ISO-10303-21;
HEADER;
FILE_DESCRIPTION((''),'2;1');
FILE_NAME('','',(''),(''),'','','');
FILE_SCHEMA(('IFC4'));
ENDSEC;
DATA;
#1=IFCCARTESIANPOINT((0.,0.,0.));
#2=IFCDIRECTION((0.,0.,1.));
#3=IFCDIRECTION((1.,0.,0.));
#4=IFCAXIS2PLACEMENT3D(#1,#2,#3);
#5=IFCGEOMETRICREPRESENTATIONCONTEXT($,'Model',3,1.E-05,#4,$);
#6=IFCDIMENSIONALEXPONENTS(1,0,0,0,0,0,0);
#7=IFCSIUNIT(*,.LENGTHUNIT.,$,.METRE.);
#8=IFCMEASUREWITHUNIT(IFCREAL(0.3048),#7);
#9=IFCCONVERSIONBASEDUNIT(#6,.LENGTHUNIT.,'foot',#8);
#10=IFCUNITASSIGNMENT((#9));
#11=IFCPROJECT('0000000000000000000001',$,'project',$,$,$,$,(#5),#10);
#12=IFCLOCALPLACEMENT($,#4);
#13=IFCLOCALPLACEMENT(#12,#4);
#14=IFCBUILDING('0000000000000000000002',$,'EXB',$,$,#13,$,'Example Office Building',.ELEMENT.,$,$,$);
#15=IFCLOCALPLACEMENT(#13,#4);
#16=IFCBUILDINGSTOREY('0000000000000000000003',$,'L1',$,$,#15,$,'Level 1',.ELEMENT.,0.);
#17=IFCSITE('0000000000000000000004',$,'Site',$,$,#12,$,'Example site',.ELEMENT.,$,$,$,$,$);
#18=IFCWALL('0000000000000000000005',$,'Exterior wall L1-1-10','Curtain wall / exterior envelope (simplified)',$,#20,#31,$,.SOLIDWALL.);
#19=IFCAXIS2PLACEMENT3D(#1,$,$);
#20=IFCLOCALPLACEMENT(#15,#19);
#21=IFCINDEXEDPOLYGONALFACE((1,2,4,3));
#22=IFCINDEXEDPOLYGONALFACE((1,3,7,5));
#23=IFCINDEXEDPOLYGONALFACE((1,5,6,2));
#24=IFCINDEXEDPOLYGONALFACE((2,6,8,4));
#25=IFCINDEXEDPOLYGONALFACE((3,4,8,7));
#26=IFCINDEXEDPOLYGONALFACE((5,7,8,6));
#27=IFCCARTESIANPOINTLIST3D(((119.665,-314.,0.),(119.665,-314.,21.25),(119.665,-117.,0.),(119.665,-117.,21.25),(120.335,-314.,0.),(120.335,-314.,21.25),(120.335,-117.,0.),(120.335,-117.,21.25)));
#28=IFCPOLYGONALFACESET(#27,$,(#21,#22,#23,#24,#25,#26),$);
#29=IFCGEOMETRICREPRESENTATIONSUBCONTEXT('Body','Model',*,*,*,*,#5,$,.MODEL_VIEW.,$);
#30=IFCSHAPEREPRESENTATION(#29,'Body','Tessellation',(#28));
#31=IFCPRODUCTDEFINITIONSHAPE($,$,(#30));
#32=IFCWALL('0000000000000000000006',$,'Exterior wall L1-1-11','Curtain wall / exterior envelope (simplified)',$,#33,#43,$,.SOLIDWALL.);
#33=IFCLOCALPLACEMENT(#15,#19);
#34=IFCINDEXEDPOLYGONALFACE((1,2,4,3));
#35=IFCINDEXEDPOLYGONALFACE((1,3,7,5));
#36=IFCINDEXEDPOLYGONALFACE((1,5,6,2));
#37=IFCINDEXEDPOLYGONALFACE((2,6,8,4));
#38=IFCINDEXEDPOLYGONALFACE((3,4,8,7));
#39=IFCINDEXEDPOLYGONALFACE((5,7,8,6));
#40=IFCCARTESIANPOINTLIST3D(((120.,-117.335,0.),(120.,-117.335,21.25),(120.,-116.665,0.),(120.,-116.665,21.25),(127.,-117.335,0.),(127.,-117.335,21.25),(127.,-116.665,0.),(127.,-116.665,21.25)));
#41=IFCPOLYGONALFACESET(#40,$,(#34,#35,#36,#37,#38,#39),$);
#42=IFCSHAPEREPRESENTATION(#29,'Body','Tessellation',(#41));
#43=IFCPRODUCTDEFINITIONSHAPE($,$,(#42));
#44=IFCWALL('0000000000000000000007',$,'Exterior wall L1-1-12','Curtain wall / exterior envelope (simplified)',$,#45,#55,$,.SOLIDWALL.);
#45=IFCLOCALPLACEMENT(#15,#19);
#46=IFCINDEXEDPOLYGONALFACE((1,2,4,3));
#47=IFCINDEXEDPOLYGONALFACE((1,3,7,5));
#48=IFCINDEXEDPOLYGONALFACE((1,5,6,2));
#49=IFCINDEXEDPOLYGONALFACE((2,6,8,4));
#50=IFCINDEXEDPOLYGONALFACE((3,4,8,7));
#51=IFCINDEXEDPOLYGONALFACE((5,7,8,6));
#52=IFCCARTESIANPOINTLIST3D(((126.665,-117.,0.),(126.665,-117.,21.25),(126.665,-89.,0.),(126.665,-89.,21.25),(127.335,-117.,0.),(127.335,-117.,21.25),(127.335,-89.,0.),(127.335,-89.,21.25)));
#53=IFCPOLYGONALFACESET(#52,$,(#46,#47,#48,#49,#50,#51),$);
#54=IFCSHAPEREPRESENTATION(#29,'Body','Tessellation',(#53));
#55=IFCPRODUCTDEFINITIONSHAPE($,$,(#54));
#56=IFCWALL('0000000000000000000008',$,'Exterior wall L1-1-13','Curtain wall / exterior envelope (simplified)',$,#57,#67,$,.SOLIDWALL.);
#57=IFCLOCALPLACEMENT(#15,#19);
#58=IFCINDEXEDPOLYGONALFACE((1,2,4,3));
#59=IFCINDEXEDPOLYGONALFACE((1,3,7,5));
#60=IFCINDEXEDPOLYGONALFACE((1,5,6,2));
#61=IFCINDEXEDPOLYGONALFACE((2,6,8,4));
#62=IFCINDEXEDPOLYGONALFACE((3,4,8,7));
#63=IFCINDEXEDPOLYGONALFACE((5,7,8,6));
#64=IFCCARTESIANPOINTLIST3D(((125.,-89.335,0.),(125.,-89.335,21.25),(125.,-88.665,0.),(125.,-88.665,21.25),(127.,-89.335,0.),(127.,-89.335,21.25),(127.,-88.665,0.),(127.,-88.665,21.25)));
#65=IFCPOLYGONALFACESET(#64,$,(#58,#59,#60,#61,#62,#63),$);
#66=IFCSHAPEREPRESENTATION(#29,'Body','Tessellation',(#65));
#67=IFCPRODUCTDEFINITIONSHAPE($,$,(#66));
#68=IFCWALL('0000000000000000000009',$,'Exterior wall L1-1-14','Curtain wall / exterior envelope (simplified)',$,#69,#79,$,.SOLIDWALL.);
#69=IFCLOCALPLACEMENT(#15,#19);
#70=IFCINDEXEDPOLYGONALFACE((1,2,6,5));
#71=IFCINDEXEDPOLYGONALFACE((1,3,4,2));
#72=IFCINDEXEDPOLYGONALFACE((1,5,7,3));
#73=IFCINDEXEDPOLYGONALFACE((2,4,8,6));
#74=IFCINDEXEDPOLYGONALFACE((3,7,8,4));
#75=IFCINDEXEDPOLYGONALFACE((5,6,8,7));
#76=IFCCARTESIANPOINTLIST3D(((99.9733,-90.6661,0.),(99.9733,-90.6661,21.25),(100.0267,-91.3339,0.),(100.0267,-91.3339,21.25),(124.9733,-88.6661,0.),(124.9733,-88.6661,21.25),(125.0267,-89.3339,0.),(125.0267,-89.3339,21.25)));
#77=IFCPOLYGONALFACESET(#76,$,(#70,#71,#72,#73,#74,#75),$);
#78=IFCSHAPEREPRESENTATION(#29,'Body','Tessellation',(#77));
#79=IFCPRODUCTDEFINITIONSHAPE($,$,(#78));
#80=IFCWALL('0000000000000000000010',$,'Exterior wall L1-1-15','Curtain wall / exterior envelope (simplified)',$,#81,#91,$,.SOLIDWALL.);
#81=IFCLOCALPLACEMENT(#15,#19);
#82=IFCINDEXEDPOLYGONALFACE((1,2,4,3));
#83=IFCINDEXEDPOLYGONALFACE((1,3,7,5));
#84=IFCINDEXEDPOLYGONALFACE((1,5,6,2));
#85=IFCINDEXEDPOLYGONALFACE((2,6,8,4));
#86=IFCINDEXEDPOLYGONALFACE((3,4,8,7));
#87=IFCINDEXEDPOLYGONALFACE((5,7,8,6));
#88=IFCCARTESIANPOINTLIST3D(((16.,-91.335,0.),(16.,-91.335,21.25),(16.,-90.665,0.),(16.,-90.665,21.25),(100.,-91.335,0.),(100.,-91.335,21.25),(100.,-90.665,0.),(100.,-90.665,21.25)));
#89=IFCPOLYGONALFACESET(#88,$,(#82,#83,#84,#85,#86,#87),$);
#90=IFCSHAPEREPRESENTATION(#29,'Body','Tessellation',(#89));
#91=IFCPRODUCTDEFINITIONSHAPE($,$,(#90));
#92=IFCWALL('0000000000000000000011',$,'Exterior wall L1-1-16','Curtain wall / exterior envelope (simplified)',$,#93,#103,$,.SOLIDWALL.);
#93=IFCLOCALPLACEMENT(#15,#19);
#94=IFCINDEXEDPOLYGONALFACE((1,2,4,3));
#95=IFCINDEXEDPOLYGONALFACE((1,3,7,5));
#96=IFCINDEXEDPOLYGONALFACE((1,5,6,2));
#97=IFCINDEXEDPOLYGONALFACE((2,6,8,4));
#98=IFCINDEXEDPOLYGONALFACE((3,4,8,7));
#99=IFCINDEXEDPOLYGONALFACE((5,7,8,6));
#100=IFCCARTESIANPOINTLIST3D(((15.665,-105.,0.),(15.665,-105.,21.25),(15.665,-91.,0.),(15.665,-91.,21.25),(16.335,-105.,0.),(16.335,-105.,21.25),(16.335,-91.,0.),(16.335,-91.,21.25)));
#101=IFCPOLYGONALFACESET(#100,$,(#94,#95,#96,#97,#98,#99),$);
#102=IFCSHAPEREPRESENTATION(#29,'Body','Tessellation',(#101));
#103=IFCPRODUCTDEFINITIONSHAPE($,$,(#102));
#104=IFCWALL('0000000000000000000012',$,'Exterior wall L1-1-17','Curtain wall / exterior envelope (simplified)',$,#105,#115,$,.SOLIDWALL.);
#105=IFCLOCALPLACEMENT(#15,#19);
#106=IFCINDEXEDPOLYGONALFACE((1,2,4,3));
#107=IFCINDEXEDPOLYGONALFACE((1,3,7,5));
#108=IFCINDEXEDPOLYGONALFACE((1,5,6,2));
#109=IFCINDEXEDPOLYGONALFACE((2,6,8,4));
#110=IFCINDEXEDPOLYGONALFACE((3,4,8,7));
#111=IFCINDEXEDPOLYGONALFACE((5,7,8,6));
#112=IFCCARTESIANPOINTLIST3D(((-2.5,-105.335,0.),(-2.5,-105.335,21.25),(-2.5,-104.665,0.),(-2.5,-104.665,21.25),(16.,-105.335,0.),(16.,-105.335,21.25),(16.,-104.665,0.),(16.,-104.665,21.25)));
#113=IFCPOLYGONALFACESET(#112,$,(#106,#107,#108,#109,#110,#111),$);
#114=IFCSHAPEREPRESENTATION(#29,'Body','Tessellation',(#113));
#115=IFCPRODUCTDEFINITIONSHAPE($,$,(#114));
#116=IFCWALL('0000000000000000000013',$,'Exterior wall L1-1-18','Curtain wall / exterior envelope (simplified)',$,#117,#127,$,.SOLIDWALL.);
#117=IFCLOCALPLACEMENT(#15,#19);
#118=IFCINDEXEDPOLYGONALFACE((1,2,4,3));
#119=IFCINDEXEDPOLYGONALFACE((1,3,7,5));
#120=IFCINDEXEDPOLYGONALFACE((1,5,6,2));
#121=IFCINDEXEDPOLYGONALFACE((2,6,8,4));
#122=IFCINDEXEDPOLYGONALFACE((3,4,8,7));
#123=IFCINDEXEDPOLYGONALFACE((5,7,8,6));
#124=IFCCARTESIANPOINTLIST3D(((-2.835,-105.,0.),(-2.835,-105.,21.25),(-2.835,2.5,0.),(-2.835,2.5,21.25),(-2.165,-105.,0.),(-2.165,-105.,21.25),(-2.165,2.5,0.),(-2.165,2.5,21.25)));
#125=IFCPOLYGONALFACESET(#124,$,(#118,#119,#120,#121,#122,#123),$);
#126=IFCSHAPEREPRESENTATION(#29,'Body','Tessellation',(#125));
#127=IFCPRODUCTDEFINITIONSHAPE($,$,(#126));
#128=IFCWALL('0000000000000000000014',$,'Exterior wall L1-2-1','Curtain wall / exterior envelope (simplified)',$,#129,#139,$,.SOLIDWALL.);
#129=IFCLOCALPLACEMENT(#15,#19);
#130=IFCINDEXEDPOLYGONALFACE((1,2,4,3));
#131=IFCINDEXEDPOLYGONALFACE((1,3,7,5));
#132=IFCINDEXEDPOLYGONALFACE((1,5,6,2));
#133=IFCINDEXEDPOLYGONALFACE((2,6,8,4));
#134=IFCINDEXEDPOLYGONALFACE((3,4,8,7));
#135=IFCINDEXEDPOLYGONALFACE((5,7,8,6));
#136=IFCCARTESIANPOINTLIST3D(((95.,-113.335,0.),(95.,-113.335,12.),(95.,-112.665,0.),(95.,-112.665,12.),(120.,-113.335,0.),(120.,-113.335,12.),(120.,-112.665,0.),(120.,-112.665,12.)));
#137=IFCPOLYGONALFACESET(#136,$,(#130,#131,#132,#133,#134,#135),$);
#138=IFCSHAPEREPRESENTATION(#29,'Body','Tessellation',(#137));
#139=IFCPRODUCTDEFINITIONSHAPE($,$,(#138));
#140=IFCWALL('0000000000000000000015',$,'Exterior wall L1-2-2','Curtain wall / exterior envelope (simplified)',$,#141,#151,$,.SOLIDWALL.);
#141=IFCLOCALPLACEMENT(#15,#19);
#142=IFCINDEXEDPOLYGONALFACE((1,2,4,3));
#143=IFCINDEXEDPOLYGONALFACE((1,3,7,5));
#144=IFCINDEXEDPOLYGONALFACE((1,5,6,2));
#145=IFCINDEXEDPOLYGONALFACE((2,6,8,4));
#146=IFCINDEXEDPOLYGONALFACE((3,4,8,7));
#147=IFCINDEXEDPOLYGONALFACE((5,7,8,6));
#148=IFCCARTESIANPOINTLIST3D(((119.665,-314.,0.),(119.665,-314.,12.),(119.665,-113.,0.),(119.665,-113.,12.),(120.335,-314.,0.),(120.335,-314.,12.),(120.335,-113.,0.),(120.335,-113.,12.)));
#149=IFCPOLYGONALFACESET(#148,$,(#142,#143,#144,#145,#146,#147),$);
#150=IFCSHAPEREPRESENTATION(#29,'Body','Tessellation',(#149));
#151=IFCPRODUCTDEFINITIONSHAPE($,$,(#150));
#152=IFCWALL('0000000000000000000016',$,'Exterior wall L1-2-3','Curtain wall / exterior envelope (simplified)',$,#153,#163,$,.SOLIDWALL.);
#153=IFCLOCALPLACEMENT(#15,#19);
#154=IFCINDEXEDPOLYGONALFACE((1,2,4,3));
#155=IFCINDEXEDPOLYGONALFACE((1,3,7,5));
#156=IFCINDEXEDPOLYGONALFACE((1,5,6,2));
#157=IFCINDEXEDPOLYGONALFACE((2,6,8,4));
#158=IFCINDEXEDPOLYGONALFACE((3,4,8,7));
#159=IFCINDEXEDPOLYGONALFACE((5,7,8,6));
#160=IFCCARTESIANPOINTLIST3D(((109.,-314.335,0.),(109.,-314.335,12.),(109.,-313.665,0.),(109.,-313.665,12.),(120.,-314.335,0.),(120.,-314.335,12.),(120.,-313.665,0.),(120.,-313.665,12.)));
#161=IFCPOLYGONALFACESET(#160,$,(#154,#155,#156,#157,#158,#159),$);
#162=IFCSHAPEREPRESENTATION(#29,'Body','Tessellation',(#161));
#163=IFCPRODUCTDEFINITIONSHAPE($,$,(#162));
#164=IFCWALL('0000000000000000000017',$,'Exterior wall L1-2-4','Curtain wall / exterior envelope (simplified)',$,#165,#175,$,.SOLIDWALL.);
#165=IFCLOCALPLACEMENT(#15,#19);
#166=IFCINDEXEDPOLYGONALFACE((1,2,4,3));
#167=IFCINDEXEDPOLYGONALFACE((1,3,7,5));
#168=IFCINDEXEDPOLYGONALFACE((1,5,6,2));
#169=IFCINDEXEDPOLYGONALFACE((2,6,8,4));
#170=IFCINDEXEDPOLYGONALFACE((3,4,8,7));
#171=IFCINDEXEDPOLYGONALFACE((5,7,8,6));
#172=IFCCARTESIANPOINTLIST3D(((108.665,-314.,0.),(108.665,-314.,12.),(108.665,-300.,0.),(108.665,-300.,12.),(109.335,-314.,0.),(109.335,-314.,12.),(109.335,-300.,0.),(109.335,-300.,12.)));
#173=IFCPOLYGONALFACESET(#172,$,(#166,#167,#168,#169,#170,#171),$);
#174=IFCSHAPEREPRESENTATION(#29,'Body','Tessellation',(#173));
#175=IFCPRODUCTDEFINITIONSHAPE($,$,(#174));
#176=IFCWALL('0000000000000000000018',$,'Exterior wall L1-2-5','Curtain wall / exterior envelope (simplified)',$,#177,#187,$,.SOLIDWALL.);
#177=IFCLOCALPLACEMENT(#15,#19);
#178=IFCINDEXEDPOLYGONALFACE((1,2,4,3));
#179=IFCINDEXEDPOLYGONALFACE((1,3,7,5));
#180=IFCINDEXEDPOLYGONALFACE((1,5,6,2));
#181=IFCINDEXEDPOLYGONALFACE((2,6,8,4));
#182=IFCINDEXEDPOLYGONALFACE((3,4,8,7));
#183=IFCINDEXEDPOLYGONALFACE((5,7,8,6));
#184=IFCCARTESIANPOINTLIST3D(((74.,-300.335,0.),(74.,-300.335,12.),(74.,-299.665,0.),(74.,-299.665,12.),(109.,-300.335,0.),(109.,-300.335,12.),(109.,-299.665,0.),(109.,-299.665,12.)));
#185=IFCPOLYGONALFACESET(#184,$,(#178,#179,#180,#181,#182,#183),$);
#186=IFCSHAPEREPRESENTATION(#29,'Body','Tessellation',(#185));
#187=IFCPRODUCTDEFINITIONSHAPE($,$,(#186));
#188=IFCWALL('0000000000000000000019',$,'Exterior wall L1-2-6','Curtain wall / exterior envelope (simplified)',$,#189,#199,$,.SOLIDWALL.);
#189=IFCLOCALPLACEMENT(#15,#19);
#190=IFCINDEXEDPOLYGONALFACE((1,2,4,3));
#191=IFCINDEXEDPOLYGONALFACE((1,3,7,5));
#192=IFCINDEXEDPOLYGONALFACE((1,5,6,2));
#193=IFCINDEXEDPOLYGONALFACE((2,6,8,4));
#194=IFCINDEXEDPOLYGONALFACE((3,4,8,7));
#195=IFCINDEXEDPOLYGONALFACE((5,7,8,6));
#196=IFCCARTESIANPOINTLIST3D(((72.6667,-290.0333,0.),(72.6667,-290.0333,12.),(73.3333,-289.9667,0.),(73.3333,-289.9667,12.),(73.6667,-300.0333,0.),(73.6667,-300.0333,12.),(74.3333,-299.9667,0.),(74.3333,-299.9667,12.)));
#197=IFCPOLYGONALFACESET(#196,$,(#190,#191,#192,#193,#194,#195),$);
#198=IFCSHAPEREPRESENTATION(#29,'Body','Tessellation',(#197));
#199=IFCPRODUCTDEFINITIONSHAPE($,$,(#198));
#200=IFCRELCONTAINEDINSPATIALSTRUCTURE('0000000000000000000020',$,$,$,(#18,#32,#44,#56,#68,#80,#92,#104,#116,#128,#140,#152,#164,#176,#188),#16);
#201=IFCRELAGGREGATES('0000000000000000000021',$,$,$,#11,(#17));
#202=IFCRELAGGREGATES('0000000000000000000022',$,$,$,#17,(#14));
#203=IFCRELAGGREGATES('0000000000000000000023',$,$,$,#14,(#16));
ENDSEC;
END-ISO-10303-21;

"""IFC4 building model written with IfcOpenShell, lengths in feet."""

from ifc_helpers import new_model, entity, si_unit, converted_unit, frame, frame_2d, origin, origin_with_axes, place, context, subcontext, project, spatial, rectangle, extrude, element, save


model = new_model("IFC4")

# Units and contexts
model_context = context("Model", 3, precision=1e-05, world=origin_with_axes())
body_context = subcontext(model_context, "Body", "Model", "MODEL_VIEW")
ifc_project = project(units=[converted_unit("LENGTHUNIT", "foot", entity("IfcReal", 0.3048), si_unit("LENGTHUNIT", "METRE"), dimensions=[1, 0, 0, 0, 0, 0, 0])], contexts=[model_context])

# Site, building, storey
site_placement = place(None, origin_with_axes())
site = spatial("IfcSite", under=ifc_project, at=site_placement, Name="Site", LongName="Example site", CompositionType="ELEMENT")
building_placement = place(site_placement, origin_with_axes())
building = spatial("IfcBuilding", under=site, at=building_placement, Name="EXB", LongName="Example Office Building", CompositionType="ELEMENT")
storey_placement = place(building_placement, origin_with_axes())
storey = spatial("IfcBuildingStorey", under=building, at=storey_placement, Name="L1", LongName="Level 1", CompositionType="ELEMENT", Elevation=0.0)

# Walls
wall_1_placement = place(storey_placement, frame((120.0, -314.0, 0.0), z_axis=(0.0, 0.0, 1.0), x_axis=(0.0, 1.0, 0.0)))
element("IfcWall", 1, at=wall_1_placement, inside=storey, Name="Exterior wall L1-1-10", Description="Curtain wall / exterior envelope (simplified)", PredefinedType="SOLIDWALL", context=body_context, shape_type="SweptSolid", body=[
    extrude(rectangle(XDim=197.0, YDim=0.67, at=frame_2d((98.5, 0.0))), origin(), (0.0, 0.0, 1.0), 21.25),
])
wall_2_placement = place(storey_placement, frame((120.0, -117.0, 0.0), z_axis=(0.0, 0.0, 1.0), x_axis=(1.0, 0.0, 0.0)))
element("IfcWall", 2, at=wall_2_placement, inside=storey, Name="Exterior wall L1-1-11", Description="Curtain wall / exterior envelope (simplified)", PredefinedType="SOLIDWALL", context=body_context, shape_type="SweptSolid", body=[
    extrude(rectangle(XDim=7.0, YDim=0.67, at=frame_2d((3.5, 0.0))), origin(), (0.0, 0.0, 1.0), 21.25),
])
wall_3_placement = place(storey_placement, frame((127.0, -117.0, 0.0), z_axis=(0.0, 0.0, 1.0), x_axis=(0.0, 1.0, 0.0)))
element("IfcWall", 3, at=wall_3_placement, inside=storey, Name="Exterior wall L1-1-12", Description="Curtain wall / exterior envelope (simplified)", PredefinedType="SOLIDWALL", context=body_context, shape_type="SweptSolid", body=[
    extrude(rectangle(XDim=28.0, YDim=0.67, at=frame_2d((14.0, 0.0))), origin(), (0.0, 0.0, 1.0), 21.25),
])
wall_4_placement = place(storey_placement, frame((127.0, -89.0, 0.0), z_axis=(0.0, 0.0, 1.0), x_axis=(-1.0, 0.0, 0.0)))
element("IfcWall", 4, at=wall_4_placement, inside=storey, Name="Exterior wall L1-1-13", Description="Curtain wall / exterior envelope (simplified)", PredefinedType="SOLIDWALL", context=body_context, shape_type="SweptSolid", body=[
    extrude(rectangle(XDim=2.0, YDim=0.67, at=frame_2d((1.0, 0.0))), origin(), (0.0, 0.0, 1.0), 21.25),
])
wall_5_placement = place(storey_placement, frame((125.0, -89.0, 0.0), z_axis=(0.0, 0.0, 1.0), x_axis=(-0.996815, -0.079745, 0.0)))
element("IfcWall", 5, at=wall_5_placement, inside=storey, Name="Exterior wall L1-1-14", Description="Curtain wall / exterior envelope (simplified)", PredefinedType="SOLIDWALL", context=body_context, shape_type="SweptSolid", body=[
    extrude(rectangle(XDim=25.0799, YDim=0.67, at=frame_2d((12.5399, 0.0))), origin(), (0.0, 0.0, 1.0), 21.25),
])
wall_6_placement = place(storey_placement, frame((100.0, -91.0, 0.0), z_axis=(0.0, 0.0, 1.0), x_axis=(-1.0, 0.0, 0.0)))
element("IfcWall", 6, at=wall_6_placement, inside=storey, Name="Exterior wall L1-1-15", Description="Curtain wall / exterior envelope (simplified)", PredefinedType="SOLIDWALL", context=body_context, shape_type="SweptSolid", body=[
    extrude(rectangle(XDim=84.0, YDim=0.67, at=frame_2d((42.0, 0.0))), origin(), (0.0, 0.0, 1.0), 21.25),
])
wall_7_placement = place(storey_placement, frame((16.0, -91.0, 0.0), z_axis=(0.0, 0.0, 1.0), x_axis=(0.0, -1.0, 0.0)))
element("IfcWall", 7, at=wall_7_placement, inside=storey, Name="Exterior wall L1-1-16", Description="Curtain wall / exterior envelope (simplified)", PredefinedType="SOLIDWALL", context=body_context, shape_type="SweptSolid", body=[
    extrude(rectangle(XDim=14.0, YDim=0.67, at=frame_2d((7.0, 0.0))), origin(), (0.0, 0.0, 1.0), 21.25),
])
wall_8_placement = place(storey_placement, frame((16.0, -105.0, 0.0), z_axis=(0.0, 0.0, 1.0), x_axis=(-1.0, 0.0, 0.0)))
element("IfcWall", 8, at=wall_8_placement, inside=storey, Name="Exterior wall L1-1-17", Description="Curtain wall / exterior envelope (simplified)", PredefinedType="SOLIDWALL", context=body_context, shape_type="SweptSolid", body=[
    extrude(rectangle(XDim=18.5, YDim=0.67, at=frame_2d((9.25, 0.0))), origin(), (0.0, 0.0, 1.0), 21.25),
])
wall_9_placement = place(storey_placement, frame((-2.5, -105.0, 0.0), z_axis=(0.0, 0.0, 1.0), x_axis=(0.0, 1.0, 0.0)))
element("IfcWall", 9, at=wall_9_placement, inside=storey, Name="Exterior wall L1-1-18", Description="Curtain wall / exterior envelope (simplified)", PredefinedType="SOLIDWALL", context=body_context, shape_type="SweptSolid", body=[
    extrude(rectangle(XDim=107.5, YDim=0.67, at=frame_2d((53.75, 0.0))), origin(), (0.0, 0.0, 1.0), 21.25),
])
wall_10_placement = place(storey_placement, frame((95.0, -113.0, 0.0), z_axis=(0.0, 0.0, 1.0), x_axis=(1.0, 0.0, 0.0)))
element("IfcWall", 10, at=wall_10_placement, inside=storey, Name="Exterior wall L1-2-1", Description="Curtain wall / exterior envelope (simplified)", PredefinedType="SOLIDWALL", context=body_context, shape_type="SweptSolid", body=[
    extrude(rectangle(XDim=25.0, YDim=0.67, at=frame_2d((12.5, 0.0))), origin(), (0.0, 0.0, 1.0), 12.0),
])
wall_11_placement = place(storey_placement, frame((120.0, -113.0, 0.0), z_axis=(0.0, 0.0, 1.0), x_axis=(0.0, -1.0, 0.0)))
element("IfcWall", 11, at=wall_11_placement, inside=storey, Name="Exterior wall L1-2-2", Description="Curtain wall / exterior envelope (simplified)", PredefinedType="SOLIDWALL", context=body_context, shape_type="SweptSolid", body=[
    extrude(rectangle(XDim=201.0, YDim=0.67, at=frame_2d((100.5, 0.0))), origin(), (0.0, 0.0, 1.0), 12.0),
])
wall_12_placement = place(storey_placement, frame((120.0, -314.0, 0.0), z_axis=(0.0, 0.0, 1.0), x_axis=(-1.0, 0.0, 0.0)))
element("IfcWall", 12, at=wall_12_placement, inside=storey, Name="Exterior wall L1-2-3", Description="Curtain wall / exterior envelope (simplified)", PredefinedType="SOLIDWALL", context=body_context, shape_type="SweptSolid", body=[
    extrude(rectangle(XDim=11.0, YDim=0.67, at=frame_2d((5.5, 0.0))), origin(), (0.0, 0.0, 1.0), 12.0),
])
wall_13_placement = place(storey_placement, frame((109.0, -314.0, 0.0), z_axis=(0.0, 0.0, 1.0), x_axis=(0.0, 1.0, 0.0)))
element("IfcWall", 13, at=wall_13_placement, inside=storey, Name="Exterior wall L1-2-4", Description="Curtain wall / exterior envelope (simplified)", PredefinedType="SOLIDWALL", context=body_context, shape_type="SweptSolid", body=[
    extrude(rectangle(XDim=14.0, YDim=0.67, at=frame_2d((7.0, 0.0))), origin(), (0.0, 0.0, 1.0), 12.0),
])
wall_14_placement = place(storey_placement, frame((109.0, -300.0, 0.0), z_axis=(0.0, 0.0, 1.0), x_axis=(-1.0, 0.0, 0.0)))
element("IfcWall", 14, at=wall_14_placement, inside=storey, Name="Exterior wall L1-2-5", Description="Curtain wall / exterior envelope (simplified)", PredefinedType="SOLIDWALL", context=body_context, shape_type="SweptSolid", body=[
    extrude(rectangle(XDim=35.0, YDim=0.67, at=frame_2d((17.5, 0.0))), origin(), (0.0, 0.0, 1.0), 12.0),
])
wall_15_placement = place(storey_placement, frame((74.0, -300.0, 0.0), z_axis=(0.0, 0.0, 1.0), x_axis=(-0.099504, 0.995037, 0.0)))
element("IfcWall", 15, at=wall_15_placement, inside=storey, Name="Exterior wall L1-2-6", Description="Curtain wall / exterior envelope (simplified)", PredefinedType="SOLIDWALL", context=body_context, shape_type="SweptSolid", body=[
    extrude(rectangle(XDim=10.0499, YDim=0.67, at=frame_2d((5.0249, 0.0))), origin(), (0.0, 0.0, 1.0), 12.0),
])

save(model, "model.ifc")
